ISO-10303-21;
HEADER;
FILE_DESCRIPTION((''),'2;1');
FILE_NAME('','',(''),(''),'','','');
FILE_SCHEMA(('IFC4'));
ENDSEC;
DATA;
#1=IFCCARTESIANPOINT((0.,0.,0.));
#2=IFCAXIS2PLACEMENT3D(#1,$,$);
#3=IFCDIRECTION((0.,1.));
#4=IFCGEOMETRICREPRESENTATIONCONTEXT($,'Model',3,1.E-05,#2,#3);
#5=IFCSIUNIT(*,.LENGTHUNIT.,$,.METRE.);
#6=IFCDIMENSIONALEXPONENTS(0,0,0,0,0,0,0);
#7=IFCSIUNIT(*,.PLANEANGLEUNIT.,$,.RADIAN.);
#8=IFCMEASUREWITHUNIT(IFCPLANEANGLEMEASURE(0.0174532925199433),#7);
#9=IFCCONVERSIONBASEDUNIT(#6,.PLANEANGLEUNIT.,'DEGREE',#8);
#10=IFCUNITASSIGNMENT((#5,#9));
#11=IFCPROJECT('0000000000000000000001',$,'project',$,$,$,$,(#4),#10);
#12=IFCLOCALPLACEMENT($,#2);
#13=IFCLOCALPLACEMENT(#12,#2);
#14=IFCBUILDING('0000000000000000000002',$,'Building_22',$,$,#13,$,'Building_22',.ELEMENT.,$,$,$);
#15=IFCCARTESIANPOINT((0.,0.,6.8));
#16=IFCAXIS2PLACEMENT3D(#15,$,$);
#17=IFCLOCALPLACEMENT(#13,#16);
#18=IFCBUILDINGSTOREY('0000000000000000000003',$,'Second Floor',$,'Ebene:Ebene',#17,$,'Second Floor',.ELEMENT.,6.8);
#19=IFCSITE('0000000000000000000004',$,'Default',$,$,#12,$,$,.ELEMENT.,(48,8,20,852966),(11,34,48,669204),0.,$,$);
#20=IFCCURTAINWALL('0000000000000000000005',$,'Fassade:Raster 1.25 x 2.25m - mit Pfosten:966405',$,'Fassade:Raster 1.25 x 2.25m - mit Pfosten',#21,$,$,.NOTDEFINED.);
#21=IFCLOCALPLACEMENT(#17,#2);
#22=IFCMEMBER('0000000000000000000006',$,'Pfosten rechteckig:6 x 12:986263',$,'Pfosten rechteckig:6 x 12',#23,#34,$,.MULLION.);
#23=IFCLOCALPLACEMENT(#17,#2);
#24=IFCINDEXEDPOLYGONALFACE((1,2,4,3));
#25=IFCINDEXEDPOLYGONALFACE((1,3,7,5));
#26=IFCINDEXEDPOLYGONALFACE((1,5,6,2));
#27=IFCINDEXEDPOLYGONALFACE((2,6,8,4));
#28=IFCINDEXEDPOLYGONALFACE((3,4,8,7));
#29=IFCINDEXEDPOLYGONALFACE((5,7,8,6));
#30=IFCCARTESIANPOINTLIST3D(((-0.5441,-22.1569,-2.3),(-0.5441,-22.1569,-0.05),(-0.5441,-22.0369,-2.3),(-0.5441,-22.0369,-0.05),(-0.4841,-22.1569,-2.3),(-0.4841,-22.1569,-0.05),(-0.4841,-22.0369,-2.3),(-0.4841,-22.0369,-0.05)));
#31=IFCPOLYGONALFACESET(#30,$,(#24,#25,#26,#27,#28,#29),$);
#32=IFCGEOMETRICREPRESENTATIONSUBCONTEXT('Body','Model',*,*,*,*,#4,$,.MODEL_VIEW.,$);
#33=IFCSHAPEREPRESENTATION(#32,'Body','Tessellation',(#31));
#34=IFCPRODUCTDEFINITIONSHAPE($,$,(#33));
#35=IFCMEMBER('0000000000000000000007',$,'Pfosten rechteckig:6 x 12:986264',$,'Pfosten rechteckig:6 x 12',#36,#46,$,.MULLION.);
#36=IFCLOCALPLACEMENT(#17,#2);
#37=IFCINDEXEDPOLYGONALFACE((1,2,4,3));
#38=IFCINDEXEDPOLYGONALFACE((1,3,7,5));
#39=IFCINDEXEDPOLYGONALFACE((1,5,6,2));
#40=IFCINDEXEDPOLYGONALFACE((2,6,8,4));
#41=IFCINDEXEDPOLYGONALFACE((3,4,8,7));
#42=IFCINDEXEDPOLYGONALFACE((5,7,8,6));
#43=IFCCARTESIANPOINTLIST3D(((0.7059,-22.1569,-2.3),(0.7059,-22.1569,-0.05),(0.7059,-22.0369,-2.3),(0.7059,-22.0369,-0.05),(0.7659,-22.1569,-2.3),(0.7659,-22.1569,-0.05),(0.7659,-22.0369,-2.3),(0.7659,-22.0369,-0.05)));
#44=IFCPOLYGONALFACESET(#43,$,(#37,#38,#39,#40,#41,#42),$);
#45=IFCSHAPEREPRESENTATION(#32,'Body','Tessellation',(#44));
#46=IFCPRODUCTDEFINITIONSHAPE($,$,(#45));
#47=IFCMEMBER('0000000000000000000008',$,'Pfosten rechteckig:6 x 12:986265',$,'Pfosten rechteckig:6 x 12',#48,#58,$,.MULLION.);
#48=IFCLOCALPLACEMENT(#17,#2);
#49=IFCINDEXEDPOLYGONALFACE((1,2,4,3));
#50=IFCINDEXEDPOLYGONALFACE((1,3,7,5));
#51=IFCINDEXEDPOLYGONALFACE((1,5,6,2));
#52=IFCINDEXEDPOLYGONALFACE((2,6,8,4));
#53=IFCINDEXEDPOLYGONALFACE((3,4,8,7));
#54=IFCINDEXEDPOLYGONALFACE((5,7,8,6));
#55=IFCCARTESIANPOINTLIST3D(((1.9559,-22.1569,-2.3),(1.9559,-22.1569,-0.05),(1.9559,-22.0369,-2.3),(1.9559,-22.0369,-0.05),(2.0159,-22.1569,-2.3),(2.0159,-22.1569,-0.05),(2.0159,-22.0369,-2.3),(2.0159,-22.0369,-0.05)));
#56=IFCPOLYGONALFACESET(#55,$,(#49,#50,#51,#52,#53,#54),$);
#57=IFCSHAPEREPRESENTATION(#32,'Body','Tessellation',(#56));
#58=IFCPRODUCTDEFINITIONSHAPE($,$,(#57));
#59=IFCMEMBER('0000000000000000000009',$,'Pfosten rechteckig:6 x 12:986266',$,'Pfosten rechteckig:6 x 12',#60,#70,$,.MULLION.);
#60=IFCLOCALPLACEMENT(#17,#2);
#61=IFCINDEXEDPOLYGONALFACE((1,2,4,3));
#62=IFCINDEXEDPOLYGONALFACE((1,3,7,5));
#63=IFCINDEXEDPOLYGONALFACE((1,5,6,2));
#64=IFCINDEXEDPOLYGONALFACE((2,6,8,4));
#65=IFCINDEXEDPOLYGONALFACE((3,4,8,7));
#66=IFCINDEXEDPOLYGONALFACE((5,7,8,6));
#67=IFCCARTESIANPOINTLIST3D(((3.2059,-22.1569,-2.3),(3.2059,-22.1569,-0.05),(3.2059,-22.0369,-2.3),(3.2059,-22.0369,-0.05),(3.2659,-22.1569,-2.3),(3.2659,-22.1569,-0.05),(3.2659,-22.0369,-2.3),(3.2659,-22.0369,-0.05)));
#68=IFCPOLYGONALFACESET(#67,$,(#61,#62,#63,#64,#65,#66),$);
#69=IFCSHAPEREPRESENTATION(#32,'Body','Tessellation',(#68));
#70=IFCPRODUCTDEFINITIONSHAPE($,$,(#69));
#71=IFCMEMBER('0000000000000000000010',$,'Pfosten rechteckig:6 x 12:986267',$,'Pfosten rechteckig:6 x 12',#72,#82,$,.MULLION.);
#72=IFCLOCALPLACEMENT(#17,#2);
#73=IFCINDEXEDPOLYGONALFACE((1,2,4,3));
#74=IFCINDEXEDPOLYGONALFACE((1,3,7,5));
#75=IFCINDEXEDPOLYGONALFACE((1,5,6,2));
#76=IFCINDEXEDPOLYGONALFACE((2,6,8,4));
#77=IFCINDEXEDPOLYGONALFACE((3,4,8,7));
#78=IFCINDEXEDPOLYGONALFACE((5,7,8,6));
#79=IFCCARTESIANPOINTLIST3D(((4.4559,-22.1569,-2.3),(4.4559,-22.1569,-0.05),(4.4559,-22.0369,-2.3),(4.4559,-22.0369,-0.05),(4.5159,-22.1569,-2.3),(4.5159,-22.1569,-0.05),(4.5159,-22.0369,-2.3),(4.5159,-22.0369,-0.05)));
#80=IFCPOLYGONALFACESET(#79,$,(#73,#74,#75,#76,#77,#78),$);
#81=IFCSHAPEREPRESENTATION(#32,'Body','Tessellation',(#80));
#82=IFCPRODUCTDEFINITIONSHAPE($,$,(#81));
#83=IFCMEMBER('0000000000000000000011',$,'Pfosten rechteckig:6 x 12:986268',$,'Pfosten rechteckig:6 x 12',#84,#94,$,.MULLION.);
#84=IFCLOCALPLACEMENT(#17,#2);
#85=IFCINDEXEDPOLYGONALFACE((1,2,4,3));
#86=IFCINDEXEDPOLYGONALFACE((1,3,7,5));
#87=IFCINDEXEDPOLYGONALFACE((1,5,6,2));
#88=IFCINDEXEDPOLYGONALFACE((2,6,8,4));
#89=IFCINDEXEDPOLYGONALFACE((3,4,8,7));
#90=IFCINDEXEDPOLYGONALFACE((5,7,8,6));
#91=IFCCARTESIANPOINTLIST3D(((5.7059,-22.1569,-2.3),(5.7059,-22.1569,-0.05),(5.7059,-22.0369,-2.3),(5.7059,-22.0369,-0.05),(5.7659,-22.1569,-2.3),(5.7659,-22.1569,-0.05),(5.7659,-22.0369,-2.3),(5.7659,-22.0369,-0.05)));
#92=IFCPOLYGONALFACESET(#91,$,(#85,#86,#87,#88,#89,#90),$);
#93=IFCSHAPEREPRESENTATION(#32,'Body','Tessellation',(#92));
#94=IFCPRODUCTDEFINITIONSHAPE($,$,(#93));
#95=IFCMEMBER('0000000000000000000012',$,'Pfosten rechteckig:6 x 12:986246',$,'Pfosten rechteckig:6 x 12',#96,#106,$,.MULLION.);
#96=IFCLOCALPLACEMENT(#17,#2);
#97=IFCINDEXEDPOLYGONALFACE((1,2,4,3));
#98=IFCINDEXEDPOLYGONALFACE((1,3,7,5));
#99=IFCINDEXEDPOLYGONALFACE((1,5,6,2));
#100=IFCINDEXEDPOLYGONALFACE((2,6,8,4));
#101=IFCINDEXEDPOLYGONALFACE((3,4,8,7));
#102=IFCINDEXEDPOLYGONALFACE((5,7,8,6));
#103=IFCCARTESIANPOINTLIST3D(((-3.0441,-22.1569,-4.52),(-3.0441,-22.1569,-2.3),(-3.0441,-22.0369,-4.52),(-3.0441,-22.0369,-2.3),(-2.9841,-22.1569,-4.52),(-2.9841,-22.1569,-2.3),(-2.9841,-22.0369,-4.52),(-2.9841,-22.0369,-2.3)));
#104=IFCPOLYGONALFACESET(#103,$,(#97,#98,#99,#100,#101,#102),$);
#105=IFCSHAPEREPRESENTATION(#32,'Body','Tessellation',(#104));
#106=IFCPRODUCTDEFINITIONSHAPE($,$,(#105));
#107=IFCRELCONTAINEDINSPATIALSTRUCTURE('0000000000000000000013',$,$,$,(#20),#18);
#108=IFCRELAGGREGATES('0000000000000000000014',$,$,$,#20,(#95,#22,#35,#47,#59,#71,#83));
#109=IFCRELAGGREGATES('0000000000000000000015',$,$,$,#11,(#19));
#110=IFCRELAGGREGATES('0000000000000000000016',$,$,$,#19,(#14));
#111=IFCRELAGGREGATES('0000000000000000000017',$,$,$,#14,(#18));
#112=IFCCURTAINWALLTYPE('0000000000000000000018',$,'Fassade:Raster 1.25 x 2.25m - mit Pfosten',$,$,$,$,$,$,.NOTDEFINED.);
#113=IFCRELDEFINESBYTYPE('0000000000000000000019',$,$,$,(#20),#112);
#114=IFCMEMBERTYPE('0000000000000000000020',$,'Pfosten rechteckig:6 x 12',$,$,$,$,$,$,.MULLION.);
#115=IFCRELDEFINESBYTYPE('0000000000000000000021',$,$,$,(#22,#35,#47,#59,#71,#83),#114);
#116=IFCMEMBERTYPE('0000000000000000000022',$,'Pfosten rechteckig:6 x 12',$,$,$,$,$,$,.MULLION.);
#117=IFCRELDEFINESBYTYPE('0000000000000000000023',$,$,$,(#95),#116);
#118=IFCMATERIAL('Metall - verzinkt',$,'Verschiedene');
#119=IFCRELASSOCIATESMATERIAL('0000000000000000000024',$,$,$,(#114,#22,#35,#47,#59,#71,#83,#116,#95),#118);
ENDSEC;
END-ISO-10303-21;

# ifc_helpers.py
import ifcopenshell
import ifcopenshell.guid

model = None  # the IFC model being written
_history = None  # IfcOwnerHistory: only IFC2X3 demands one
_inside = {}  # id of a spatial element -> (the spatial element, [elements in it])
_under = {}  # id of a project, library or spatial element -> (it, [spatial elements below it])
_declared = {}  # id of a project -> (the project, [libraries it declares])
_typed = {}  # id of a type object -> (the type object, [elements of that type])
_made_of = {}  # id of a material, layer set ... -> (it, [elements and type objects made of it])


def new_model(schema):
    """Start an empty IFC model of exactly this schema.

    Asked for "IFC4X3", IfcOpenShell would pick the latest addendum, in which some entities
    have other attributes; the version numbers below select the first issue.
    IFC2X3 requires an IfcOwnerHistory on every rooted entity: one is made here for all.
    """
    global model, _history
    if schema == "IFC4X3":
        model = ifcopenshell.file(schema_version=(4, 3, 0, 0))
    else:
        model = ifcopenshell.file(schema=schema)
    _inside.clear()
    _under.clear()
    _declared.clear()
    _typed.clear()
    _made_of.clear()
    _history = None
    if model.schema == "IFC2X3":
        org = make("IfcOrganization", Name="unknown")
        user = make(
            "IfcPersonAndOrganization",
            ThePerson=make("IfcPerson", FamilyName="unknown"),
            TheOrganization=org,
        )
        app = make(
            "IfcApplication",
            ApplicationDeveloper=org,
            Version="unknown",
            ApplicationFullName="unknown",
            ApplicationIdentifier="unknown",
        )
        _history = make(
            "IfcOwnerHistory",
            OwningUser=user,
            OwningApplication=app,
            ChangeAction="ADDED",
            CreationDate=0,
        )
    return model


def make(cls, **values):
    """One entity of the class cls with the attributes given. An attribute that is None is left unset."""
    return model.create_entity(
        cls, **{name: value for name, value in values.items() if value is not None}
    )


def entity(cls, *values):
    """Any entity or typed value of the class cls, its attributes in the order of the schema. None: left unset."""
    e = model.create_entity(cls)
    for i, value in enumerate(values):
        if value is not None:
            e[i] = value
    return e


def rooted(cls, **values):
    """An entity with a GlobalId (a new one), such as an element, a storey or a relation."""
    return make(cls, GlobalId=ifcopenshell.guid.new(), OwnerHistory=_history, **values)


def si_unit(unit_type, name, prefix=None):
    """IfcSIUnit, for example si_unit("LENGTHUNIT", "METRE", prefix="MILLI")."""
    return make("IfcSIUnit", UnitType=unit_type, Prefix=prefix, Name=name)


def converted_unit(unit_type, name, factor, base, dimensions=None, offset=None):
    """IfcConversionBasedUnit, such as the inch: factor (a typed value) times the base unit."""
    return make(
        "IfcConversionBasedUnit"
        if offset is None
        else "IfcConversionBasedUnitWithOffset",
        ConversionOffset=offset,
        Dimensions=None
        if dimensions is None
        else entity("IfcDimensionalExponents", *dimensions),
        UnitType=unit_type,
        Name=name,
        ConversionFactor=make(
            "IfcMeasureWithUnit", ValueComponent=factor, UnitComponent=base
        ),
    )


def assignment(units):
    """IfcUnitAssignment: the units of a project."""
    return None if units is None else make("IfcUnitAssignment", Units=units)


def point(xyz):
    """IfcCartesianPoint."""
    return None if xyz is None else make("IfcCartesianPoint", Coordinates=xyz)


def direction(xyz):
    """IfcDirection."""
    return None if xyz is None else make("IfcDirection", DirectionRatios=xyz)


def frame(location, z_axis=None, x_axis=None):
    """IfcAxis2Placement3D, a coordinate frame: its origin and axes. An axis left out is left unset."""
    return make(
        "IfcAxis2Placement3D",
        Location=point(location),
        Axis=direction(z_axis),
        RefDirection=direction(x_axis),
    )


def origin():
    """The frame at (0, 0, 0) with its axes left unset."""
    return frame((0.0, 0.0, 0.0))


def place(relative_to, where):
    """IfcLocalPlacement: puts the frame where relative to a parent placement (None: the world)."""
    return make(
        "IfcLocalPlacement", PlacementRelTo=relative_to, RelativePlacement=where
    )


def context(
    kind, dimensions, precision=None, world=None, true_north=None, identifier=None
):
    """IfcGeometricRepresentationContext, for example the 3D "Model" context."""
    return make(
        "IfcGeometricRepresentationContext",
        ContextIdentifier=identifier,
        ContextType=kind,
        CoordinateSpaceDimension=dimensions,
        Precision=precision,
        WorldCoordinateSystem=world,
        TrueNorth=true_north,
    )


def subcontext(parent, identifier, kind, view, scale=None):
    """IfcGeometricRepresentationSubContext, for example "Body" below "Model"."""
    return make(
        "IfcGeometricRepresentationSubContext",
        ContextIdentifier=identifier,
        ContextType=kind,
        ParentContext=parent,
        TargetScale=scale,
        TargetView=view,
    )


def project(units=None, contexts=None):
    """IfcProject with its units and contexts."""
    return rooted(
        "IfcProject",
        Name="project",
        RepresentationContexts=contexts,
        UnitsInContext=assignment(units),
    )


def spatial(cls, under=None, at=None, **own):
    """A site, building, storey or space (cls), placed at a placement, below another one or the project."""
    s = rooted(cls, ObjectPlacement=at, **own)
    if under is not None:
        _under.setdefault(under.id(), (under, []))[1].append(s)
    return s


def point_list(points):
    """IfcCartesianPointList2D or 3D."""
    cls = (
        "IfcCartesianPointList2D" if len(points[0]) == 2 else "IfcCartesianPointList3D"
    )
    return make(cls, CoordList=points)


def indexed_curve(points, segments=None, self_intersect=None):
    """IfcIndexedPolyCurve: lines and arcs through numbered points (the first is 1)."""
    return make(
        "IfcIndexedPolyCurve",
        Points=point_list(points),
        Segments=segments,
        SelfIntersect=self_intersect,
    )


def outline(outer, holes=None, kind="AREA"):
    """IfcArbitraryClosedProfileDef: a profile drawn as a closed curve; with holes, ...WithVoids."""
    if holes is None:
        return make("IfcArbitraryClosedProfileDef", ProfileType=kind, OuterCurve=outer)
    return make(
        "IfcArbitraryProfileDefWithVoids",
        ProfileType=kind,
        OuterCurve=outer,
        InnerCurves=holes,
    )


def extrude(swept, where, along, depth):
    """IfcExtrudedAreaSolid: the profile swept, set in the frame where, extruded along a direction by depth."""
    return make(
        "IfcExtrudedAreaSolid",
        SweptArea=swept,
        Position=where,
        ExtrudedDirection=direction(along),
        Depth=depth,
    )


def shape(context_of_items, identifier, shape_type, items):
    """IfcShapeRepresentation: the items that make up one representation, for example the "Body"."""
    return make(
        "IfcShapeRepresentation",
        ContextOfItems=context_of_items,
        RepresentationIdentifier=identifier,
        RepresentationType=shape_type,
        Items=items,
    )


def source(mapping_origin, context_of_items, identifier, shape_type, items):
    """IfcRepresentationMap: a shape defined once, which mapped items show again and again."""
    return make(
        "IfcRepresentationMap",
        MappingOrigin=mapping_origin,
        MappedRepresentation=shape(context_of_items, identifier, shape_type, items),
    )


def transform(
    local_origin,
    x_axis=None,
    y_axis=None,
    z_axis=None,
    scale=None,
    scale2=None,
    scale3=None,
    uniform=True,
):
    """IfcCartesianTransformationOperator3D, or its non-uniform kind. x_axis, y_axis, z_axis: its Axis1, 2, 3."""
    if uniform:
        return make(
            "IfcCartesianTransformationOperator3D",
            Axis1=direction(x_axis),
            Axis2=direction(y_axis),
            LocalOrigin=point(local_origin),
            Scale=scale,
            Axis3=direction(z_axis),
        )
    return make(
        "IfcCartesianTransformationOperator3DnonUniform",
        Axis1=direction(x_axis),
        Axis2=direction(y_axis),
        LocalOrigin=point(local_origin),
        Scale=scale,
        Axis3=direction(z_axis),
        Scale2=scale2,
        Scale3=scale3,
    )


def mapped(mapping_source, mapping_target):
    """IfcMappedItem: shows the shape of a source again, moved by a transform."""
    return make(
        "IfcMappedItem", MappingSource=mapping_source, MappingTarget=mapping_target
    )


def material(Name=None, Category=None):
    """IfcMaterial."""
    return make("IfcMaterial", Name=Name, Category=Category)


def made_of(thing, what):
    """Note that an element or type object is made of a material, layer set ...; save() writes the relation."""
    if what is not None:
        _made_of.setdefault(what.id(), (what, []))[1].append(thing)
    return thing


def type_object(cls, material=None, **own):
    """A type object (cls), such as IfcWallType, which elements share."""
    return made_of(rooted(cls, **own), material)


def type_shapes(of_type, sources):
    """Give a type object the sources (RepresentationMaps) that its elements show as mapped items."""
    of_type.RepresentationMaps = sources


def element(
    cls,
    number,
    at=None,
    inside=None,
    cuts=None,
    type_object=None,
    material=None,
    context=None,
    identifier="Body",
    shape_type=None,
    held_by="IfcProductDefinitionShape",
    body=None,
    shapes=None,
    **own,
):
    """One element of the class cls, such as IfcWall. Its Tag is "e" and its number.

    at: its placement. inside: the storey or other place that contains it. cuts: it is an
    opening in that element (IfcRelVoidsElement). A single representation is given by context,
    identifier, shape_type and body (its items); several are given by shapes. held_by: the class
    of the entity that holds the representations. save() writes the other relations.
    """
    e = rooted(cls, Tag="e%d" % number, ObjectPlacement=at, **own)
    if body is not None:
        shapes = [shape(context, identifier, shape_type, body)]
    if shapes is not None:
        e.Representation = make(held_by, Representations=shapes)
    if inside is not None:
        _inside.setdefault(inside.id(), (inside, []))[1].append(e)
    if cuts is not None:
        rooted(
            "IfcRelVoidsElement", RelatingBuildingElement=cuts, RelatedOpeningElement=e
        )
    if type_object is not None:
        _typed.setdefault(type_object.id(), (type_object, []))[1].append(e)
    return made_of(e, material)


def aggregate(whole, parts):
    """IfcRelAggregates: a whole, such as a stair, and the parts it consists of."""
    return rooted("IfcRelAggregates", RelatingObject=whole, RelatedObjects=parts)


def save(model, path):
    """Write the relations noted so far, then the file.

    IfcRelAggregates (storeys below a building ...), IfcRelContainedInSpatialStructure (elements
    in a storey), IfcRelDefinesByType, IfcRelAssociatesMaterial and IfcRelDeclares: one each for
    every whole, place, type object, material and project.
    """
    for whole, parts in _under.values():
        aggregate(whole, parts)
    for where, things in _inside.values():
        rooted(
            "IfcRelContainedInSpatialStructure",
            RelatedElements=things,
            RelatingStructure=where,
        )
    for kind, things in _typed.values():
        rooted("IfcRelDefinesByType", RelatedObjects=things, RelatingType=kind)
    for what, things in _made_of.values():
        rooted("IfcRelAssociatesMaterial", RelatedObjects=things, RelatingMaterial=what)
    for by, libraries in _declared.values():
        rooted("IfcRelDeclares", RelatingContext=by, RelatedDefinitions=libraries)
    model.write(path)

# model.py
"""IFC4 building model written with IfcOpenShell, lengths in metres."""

from ifc_helpers import new_model, entity, si_unit, converted_unit, direction, frame, origin, place, context, subcontext, project, spatial, indexed_curve, outline, extrude, source, transform, mapped, material, type_object, type_shapes, element, aggregate, save


model = new_model("IFC4")

# Units and contexts
model_context = context("Model", 3, precision=1e-05, world=origin(), true_north=direction((0.0, 1.0)))
body_context = subcontext(model_context, "Body", "Model", "MODEL_VIEW")
ifc_project = project(units=[si_unit("LENGTHUNIT", "METRE"), converted_unit("PLANEANGLEUNIT", "DEGREE", entity("IfcPlaneAngleMeasure", 0.0174532925199433), si_unit("PLANEANGLEUNIT", "RADIAN"), dimensions=[0, 0, 0, 0, 0, 0, 0])], contexts=[model_context])

# Site, building, storey
site_placement = place(None, origin())
site = spatial("IfcSite", under=ifc_project, at=site_placement, Name="Default", CompositionType="ELEMENT", RefLatitude=(48, 8, 20, 852966), RefLongitude=(11, 34, 48, 669204), RefElevation=0.0)
building_placement = place(site_placement, origin())
building = spatial("IfcBuilding", under=site, at=building_placement, Name="Building_22", LongName="Building_22", CompositionType="ELEMENT")
storey_placement = place(building_placement, frame((0.0, 0.0, 6.8)))
storey = spatial("IfcBuildingStorey", under=building, at=storey_placement, Name="Second Floor", ObjectType="Ebene:Ebene", LongName="Second Floor", CompositionType="ELEMENT", Elevation=6.8)

# Curtain wall, members
curtain_wall_type = type_object("IfcCurtainWallType", Name="Fassade:Raster 1.25 x 2.25m - mit Pfosten", PredefinedType="NOTDEFINED")
curtain_wall_placement = place(storey_placement, frame((0.0, 0.0, -6.8)))
curtain_wall = element("IfcCurtainWall", 1, at=curtain_wall_placement, inside=storey, type_object=curtain_wall_type, Name="Fassade:Raster 1.25 x 2.25m - mit Pfosten:966405", ObjectType="Fassade:Raster 1.25 x 2.25m - mit Pfosten", PredefinedType="NOTDEFINED")
ifc_material = material(Name="Metall - verzinkt", Category="Verschiedene")
member_type_1 = type_object("IfcMemberType", Name="Pfosten rechteckig:6 x 12", PredefinedType="MULLION", material=ifc_material)
shared_shape_1 = source(origin(), body_context, "Body", "SweptSolid", [
    extrude(outline(indexed_curve([(-0.03, -0.06), (0.03, -0.06), (0.03, 0.06), (-0.03, 0.06), (-0.03, -0.06)], self_intersect=False)), frame((0.0, 0.0, -2.25), z_axis=(0.0, 0.0, 1.0), x_axis=(-1.0, 0.0, 0.0)), (0.0, 0.0, 1.0), 2.25),
])
type_shapes(member_type_1, [shared_shape_1])
member_1_placement = place(curtain_wall_placement, frame((-0.5141, -22.0969, 4.5), z_axis=(0.0, 0.0, -1.0), x_axis=(1.0, 0.0, 0.0)))
member_1 = element("IfcMember", 2, at=member_1_placement, type_object=member_type_1, material=ifc_material, Name="Pfosten rechteckig:6 x 12:986263", ObjectType="Pfosten rechteckig:6 x 12", PredefinedType="MULLION", context=body_context, shape_type="MappedRepresentation", body=[
    mapped(shared_shape_1, transform((0.0, 0.0, 0.0), scale=1.0)),
])
member_2_placement = place(curtain_wall_placement, frame((0.7359, -22.0969, 4.5), z_axis=(0.0, 0.0, -1.0), x_axis=(1.0, 0.0, 0.0)))
member_2 = element("IfcMember", 3, at=member_2_placement, type_object=member_type_1, material=ifc_material, Name="Pfosten rechteckig:6 x 12:986264", ObjectType="Pfosten rechteckig:6 x 12", PredefinedType="MULLION", context=body_context, shape_type="MappedRepresentation", body=[
    mapped(shared_shape_1, transform((0.0, 0.0, 0.0), scale=1.0)),
])
member_3_placement = place(curtain_wall_placement, frame((1.9859, -22.0969, 4.5), z_axis=(0.0, 0.0, -1.0), x_axis=(1.0, 0.0, 0.0)))
member_3 = element("IfcMember", 4, at=member_3_placement, type_object=member_type_1, material=ifc_material, Name="Pfosten rechteckig:6 x 12:986265", ObjectType="Pfosten rechteckig:6 x 12", PredefinedType="MULLION", context=body_context, shape_type="MappedRepresentation", body=[
    mapped(shared_shape_1, transform((0.0, 0.0, 0.0), scale=1.0)),
])
member_4_placement = place(curtain_wall_placement, frame((3.2359, -22.0969, 4.5), z_axis=(0.0, 0.0, -1.0), x_axis=(1.0, 0.0, 0.0)))
member_4 = element("IfcMember", 5, at=member_4_placement, type_object=member_type_1, material=ifc_material, Name="Pfosten rechteckig:6 x 12:986266", ObjectType="Pfosten rechteckig:6 x 12", PredefinedType="MULLION", context=body_context, shape_type="MappedRepresentation", body=[
    mapped(shared_shape_1, transform((0.0, 0.0, 0.0), scale=1.0)),
])
member_5_placement = place(curtain_wall_placement, frame((4.4859, -22.0969, 4.5), z_axis=(0.0, 0.0, -1.0), x_axis=(1.0, 0.0, 0.0)))
member_5 = element("IfcMember", 6, at=member_5_placement, type_object=member_type_1, material=ifc_material, Name="Pfosten rechteckig:6 x 12:986267", ObjectType="Pfosten rechteckig:6 x 12", PredefinedType="MULLION", context=body_context, shape_type="MappedRepresentation", body=[
    mapped(shared_shape_1, transform((0.0, 0.0, 0.0), scale=1.0)),
])
member_6_placement = place(curtain_wall_placement, frame((5.7359, -22.0969, 4.5), z_axis=(0.0, 0.0, -1.0), x_axis=(1.0, 0.0, 0.0)))
member_6 = element("IfcMember", 7, at=member_6_placement, type_object=member_type_1, material=ifc_material, Name="Pfosten rechteckig:6 x 12:986268", ObjectType="Pfosten rechteckig:6 x 12", PredefinedType="MULLION", context=body_context, shape_type="MappedRepresentation", body=[
    mapped(shared_shape_1, transform((0.0, 0.0, 0.0), scale=1.0)),
])
member_type_2 = type_object("IfcMemberType", Name="Pfosten rechteckig:6 x 12", PredefinedType="MULLION", material=ifc_material)
shared_shape_2 = source(origin(), body_context, "Body", "SweptSolid", [
    extrude(outline(indexed_curve([(-0.03, -0.06), (0.03, -0.06), (0.03, 0.06), (-0.03, 0.06), (-0.03, -0.06)], self_intersect=False)), frame((0.0, 0.0, -2.22), z_axis=(0.0, 0.0, 1.0), x_axis=(-1.0, 0.0, 0.0)), (0.0, 0.0, 1.0), 2.22),
])
type_shapes(member_type_2, [shared_shape_2])
member_7_placement = place(curtain_wall_placement, frame((-3.0141, -22.0969, 2.28), z_axis=(0.0, 0.0, -1.0), x_axis=(1.0, 0.0, 0.0)))
member_7 = element("IfcMember", 8, at=member_7_placement, type_object=member_type_2, material=ifc_material, Name="Pfosten rechteckig:6 x 12:986246", ObjectType="Pfosten rechteckig:6 x 12", PredefinedType="MULLION", context=body_context, shape_type="MappedRepresentation", body=[
    mapped(shared_shape_2, transform((0.0, 0.0, 0.0), scale=1.0)),
])
aggregate(curtain_wall, [member_7, member_1, member_2, member_3, member_4, member_5, member_6])

save(model, "model.ifc")
